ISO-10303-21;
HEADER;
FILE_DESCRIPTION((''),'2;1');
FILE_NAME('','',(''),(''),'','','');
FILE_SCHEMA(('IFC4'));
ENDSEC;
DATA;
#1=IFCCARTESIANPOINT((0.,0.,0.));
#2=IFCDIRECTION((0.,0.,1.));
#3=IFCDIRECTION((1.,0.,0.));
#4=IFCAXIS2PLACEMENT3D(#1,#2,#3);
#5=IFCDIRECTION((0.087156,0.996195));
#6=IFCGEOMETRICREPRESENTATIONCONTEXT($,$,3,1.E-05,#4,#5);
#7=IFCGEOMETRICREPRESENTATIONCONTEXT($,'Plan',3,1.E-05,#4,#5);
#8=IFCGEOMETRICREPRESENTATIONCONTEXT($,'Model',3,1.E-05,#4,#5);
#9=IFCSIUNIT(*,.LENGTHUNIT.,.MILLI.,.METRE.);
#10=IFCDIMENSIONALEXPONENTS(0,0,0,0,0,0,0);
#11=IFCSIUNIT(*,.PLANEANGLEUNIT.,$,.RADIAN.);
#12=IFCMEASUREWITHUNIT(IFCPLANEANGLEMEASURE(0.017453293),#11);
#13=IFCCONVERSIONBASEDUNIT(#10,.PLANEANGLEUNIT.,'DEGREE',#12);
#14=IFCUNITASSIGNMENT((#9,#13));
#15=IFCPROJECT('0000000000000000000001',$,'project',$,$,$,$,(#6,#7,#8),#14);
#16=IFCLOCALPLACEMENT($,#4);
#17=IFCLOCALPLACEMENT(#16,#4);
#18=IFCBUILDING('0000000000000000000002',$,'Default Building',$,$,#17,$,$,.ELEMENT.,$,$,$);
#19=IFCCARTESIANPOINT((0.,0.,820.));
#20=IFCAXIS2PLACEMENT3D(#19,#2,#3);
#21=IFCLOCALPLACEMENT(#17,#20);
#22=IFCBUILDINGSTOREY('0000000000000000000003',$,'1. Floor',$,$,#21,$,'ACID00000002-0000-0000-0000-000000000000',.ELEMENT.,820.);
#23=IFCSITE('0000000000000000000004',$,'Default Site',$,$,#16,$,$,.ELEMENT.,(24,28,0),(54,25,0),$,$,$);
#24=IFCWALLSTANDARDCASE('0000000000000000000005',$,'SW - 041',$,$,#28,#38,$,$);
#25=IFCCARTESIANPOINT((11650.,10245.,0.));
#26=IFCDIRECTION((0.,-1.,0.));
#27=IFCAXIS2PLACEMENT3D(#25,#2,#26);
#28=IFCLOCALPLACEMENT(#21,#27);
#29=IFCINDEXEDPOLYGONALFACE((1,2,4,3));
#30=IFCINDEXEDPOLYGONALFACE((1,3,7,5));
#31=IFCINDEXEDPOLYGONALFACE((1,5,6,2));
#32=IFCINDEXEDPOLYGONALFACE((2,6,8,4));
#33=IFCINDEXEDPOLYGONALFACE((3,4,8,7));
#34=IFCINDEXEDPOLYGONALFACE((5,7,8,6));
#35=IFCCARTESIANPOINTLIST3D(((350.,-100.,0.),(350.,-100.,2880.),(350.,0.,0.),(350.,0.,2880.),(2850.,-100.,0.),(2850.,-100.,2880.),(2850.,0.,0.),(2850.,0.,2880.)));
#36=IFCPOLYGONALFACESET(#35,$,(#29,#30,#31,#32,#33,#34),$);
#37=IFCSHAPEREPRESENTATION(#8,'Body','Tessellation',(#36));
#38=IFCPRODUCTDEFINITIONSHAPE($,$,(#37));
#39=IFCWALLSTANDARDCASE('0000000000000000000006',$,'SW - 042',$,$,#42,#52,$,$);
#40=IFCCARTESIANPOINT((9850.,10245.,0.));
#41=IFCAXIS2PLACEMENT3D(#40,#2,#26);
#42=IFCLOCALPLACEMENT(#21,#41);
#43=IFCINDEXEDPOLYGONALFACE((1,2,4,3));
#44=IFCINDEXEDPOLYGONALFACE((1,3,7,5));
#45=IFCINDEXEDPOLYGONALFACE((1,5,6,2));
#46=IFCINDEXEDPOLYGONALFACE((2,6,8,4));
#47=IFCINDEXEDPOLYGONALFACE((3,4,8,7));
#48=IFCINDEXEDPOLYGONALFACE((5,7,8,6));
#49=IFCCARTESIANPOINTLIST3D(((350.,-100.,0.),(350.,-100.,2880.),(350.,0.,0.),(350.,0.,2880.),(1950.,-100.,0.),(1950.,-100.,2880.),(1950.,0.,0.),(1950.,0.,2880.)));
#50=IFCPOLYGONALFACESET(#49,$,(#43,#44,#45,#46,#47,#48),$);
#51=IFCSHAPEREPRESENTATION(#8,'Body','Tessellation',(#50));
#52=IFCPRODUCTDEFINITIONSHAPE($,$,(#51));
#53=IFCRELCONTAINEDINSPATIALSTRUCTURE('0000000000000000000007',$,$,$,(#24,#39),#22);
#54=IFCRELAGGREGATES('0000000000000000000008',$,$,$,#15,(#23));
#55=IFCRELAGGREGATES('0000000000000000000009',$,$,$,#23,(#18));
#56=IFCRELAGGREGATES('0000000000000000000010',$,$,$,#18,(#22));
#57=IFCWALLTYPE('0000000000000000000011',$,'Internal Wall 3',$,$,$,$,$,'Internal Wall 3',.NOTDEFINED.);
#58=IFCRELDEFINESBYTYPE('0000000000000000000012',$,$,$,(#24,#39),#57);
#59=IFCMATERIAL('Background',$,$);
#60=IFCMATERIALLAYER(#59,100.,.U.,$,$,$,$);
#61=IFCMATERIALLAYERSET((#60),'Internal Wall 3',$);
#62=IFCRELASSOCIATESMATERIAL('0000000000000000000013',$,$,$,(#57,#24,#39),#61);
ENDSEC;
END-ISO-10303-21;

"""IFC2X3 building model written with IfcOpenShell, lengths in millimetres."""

from ifc_helpers import new_model, entity, si_unit, converted_unit, direction, frame, origin_with_axes, place, context, project, spatial, polyline, outline, extrude, material, layer, layer_set, layer_usage, type_object, element, save


model = new_model("IFC2X3")

# Units and contexts
context_of_model = context(None, 3, precision=1e-05, world=origin_with_axes(), true_north=direction((0.087156, 0.996195)))
plan_context = context("Plan", 3, precision=1e-05, world=origin_with_axes(), true_north=direction((0.087156, 0.996195)))
model_context = context("Model", 3, precision=1e-05, world=origin_with_axes(), true_north=direction((0.087156, 0.996195)))
ifc_project = project(units=[si_unit("LENGTHUNIT", "METRE", prefix="MILLI"), converted_unit("PLANEANGLEUNIT", "DEGREE", entity("IfcPlaneAngleMeasure", 0.017453293), si_unit("PLANEANGLEUNIT", "RADIAN"), dimensions=[0, 0, 0, 0, 0, 0, 0])], contexts=[context_of_model, plan_context, model_context])

# Site, building, storey
site_placement = place(None, origin_with_axes())
site = spatial("IfcSite", under=ifc_project, at=site_placement, Name="Default Site", CompositionType="ELEMENT", RefLatitude=(24, 28, 0), RefLongitude=(54, 25, 0))
building_placement = place(site_placement, origin_with_axes())
building = spatial("IfcBuilding", under=site, at=building_placement, Name="Default Building", CompositionType="ELEMENT")
storey_placement = place(building_placement, frame((0.0, 0.0, 820.0), z_axis=(0.0, 0.0, 1.0), x_axis=(1.0, 0.0, 0.0)))
storey = spatial("IfcBuildingStorey", under=building, at=storey_placement, Name="1. Floor", LongName="ACID00000002-0000-0000-0000-000000000000", CompositionType="ELEMENT", Elevation=820.0)

# Shared definitions
ifc_material_1 = material(Name="Background")

# Walls
ifc_layer_1 = layer(ifc_material_1, 100.0, ventilated="UNKNOWN")
ifc_layer_set_1 = layer_set([ifc_layer_1], Name="Internal Wall 3")
wall_type_1 = type_object("IfcWallType", Name="Internal Wall 3", ElementType="Internal Wall 3", PredefinedType="NOTDEFINED", material=ifc_layer_set_1)
ifc_layer_usage_1 = layer_usage(ifc_layer_set_1, "AXIS2", "NEGATIVE", 0.0)
wall_1_placement = place(storey_placement, frame((11650.0, 10245.0, 0.0), z_axis=(0.0, 0.0, 1.0), x_axis=(0.0, -1.0, 0.0)))
element("IfcWallStandardCase", 1, at=wall_1_placement, inside=storey, type_object=wall_type_1, material=ifc_layer_usage_1, Name="SW - 041", context=model_context, shape_type="SweptSolid", body=[
    extrude(outline(polyline([(350.0, -100.0), (2850.0, -100.0), (2850.0, 0.0), (350.0, 0.0), (350.0, -100.0)])), origin_with_axes(), (0.0, 0.0, 1.0), 2880.0),
])
ifc_layer_usage_2 = layer_usage(ifc_layer_set_1, "AXIS2", "NEGATIVE", 0.0)
wall_2_placement = place(storey_placement, frame((9850.0, 10245.0, 0.0), z_axis=(0.0, 0.0, 1.0), x_axis=(0.0, -1.0, 0.0)))
element("IfcWallStandardCase", 2, at=wall_2_placement, inside=storey, type_object=wall_type_1, material=ifc_layer_usage_2, Name="SW - 042", context=model_context, shape_type="SweptSolid", body=[
    extrude(outline(polyline([(350.0, -100.0), (1950.0, -100.0), (1950.0, 0.0), (350.0, 0.0), (350.0, -100.0)])), origin_with_axes(), (0.0, 0.0, 1.0), 2880.0),
])

save(model, "model.ifc")
